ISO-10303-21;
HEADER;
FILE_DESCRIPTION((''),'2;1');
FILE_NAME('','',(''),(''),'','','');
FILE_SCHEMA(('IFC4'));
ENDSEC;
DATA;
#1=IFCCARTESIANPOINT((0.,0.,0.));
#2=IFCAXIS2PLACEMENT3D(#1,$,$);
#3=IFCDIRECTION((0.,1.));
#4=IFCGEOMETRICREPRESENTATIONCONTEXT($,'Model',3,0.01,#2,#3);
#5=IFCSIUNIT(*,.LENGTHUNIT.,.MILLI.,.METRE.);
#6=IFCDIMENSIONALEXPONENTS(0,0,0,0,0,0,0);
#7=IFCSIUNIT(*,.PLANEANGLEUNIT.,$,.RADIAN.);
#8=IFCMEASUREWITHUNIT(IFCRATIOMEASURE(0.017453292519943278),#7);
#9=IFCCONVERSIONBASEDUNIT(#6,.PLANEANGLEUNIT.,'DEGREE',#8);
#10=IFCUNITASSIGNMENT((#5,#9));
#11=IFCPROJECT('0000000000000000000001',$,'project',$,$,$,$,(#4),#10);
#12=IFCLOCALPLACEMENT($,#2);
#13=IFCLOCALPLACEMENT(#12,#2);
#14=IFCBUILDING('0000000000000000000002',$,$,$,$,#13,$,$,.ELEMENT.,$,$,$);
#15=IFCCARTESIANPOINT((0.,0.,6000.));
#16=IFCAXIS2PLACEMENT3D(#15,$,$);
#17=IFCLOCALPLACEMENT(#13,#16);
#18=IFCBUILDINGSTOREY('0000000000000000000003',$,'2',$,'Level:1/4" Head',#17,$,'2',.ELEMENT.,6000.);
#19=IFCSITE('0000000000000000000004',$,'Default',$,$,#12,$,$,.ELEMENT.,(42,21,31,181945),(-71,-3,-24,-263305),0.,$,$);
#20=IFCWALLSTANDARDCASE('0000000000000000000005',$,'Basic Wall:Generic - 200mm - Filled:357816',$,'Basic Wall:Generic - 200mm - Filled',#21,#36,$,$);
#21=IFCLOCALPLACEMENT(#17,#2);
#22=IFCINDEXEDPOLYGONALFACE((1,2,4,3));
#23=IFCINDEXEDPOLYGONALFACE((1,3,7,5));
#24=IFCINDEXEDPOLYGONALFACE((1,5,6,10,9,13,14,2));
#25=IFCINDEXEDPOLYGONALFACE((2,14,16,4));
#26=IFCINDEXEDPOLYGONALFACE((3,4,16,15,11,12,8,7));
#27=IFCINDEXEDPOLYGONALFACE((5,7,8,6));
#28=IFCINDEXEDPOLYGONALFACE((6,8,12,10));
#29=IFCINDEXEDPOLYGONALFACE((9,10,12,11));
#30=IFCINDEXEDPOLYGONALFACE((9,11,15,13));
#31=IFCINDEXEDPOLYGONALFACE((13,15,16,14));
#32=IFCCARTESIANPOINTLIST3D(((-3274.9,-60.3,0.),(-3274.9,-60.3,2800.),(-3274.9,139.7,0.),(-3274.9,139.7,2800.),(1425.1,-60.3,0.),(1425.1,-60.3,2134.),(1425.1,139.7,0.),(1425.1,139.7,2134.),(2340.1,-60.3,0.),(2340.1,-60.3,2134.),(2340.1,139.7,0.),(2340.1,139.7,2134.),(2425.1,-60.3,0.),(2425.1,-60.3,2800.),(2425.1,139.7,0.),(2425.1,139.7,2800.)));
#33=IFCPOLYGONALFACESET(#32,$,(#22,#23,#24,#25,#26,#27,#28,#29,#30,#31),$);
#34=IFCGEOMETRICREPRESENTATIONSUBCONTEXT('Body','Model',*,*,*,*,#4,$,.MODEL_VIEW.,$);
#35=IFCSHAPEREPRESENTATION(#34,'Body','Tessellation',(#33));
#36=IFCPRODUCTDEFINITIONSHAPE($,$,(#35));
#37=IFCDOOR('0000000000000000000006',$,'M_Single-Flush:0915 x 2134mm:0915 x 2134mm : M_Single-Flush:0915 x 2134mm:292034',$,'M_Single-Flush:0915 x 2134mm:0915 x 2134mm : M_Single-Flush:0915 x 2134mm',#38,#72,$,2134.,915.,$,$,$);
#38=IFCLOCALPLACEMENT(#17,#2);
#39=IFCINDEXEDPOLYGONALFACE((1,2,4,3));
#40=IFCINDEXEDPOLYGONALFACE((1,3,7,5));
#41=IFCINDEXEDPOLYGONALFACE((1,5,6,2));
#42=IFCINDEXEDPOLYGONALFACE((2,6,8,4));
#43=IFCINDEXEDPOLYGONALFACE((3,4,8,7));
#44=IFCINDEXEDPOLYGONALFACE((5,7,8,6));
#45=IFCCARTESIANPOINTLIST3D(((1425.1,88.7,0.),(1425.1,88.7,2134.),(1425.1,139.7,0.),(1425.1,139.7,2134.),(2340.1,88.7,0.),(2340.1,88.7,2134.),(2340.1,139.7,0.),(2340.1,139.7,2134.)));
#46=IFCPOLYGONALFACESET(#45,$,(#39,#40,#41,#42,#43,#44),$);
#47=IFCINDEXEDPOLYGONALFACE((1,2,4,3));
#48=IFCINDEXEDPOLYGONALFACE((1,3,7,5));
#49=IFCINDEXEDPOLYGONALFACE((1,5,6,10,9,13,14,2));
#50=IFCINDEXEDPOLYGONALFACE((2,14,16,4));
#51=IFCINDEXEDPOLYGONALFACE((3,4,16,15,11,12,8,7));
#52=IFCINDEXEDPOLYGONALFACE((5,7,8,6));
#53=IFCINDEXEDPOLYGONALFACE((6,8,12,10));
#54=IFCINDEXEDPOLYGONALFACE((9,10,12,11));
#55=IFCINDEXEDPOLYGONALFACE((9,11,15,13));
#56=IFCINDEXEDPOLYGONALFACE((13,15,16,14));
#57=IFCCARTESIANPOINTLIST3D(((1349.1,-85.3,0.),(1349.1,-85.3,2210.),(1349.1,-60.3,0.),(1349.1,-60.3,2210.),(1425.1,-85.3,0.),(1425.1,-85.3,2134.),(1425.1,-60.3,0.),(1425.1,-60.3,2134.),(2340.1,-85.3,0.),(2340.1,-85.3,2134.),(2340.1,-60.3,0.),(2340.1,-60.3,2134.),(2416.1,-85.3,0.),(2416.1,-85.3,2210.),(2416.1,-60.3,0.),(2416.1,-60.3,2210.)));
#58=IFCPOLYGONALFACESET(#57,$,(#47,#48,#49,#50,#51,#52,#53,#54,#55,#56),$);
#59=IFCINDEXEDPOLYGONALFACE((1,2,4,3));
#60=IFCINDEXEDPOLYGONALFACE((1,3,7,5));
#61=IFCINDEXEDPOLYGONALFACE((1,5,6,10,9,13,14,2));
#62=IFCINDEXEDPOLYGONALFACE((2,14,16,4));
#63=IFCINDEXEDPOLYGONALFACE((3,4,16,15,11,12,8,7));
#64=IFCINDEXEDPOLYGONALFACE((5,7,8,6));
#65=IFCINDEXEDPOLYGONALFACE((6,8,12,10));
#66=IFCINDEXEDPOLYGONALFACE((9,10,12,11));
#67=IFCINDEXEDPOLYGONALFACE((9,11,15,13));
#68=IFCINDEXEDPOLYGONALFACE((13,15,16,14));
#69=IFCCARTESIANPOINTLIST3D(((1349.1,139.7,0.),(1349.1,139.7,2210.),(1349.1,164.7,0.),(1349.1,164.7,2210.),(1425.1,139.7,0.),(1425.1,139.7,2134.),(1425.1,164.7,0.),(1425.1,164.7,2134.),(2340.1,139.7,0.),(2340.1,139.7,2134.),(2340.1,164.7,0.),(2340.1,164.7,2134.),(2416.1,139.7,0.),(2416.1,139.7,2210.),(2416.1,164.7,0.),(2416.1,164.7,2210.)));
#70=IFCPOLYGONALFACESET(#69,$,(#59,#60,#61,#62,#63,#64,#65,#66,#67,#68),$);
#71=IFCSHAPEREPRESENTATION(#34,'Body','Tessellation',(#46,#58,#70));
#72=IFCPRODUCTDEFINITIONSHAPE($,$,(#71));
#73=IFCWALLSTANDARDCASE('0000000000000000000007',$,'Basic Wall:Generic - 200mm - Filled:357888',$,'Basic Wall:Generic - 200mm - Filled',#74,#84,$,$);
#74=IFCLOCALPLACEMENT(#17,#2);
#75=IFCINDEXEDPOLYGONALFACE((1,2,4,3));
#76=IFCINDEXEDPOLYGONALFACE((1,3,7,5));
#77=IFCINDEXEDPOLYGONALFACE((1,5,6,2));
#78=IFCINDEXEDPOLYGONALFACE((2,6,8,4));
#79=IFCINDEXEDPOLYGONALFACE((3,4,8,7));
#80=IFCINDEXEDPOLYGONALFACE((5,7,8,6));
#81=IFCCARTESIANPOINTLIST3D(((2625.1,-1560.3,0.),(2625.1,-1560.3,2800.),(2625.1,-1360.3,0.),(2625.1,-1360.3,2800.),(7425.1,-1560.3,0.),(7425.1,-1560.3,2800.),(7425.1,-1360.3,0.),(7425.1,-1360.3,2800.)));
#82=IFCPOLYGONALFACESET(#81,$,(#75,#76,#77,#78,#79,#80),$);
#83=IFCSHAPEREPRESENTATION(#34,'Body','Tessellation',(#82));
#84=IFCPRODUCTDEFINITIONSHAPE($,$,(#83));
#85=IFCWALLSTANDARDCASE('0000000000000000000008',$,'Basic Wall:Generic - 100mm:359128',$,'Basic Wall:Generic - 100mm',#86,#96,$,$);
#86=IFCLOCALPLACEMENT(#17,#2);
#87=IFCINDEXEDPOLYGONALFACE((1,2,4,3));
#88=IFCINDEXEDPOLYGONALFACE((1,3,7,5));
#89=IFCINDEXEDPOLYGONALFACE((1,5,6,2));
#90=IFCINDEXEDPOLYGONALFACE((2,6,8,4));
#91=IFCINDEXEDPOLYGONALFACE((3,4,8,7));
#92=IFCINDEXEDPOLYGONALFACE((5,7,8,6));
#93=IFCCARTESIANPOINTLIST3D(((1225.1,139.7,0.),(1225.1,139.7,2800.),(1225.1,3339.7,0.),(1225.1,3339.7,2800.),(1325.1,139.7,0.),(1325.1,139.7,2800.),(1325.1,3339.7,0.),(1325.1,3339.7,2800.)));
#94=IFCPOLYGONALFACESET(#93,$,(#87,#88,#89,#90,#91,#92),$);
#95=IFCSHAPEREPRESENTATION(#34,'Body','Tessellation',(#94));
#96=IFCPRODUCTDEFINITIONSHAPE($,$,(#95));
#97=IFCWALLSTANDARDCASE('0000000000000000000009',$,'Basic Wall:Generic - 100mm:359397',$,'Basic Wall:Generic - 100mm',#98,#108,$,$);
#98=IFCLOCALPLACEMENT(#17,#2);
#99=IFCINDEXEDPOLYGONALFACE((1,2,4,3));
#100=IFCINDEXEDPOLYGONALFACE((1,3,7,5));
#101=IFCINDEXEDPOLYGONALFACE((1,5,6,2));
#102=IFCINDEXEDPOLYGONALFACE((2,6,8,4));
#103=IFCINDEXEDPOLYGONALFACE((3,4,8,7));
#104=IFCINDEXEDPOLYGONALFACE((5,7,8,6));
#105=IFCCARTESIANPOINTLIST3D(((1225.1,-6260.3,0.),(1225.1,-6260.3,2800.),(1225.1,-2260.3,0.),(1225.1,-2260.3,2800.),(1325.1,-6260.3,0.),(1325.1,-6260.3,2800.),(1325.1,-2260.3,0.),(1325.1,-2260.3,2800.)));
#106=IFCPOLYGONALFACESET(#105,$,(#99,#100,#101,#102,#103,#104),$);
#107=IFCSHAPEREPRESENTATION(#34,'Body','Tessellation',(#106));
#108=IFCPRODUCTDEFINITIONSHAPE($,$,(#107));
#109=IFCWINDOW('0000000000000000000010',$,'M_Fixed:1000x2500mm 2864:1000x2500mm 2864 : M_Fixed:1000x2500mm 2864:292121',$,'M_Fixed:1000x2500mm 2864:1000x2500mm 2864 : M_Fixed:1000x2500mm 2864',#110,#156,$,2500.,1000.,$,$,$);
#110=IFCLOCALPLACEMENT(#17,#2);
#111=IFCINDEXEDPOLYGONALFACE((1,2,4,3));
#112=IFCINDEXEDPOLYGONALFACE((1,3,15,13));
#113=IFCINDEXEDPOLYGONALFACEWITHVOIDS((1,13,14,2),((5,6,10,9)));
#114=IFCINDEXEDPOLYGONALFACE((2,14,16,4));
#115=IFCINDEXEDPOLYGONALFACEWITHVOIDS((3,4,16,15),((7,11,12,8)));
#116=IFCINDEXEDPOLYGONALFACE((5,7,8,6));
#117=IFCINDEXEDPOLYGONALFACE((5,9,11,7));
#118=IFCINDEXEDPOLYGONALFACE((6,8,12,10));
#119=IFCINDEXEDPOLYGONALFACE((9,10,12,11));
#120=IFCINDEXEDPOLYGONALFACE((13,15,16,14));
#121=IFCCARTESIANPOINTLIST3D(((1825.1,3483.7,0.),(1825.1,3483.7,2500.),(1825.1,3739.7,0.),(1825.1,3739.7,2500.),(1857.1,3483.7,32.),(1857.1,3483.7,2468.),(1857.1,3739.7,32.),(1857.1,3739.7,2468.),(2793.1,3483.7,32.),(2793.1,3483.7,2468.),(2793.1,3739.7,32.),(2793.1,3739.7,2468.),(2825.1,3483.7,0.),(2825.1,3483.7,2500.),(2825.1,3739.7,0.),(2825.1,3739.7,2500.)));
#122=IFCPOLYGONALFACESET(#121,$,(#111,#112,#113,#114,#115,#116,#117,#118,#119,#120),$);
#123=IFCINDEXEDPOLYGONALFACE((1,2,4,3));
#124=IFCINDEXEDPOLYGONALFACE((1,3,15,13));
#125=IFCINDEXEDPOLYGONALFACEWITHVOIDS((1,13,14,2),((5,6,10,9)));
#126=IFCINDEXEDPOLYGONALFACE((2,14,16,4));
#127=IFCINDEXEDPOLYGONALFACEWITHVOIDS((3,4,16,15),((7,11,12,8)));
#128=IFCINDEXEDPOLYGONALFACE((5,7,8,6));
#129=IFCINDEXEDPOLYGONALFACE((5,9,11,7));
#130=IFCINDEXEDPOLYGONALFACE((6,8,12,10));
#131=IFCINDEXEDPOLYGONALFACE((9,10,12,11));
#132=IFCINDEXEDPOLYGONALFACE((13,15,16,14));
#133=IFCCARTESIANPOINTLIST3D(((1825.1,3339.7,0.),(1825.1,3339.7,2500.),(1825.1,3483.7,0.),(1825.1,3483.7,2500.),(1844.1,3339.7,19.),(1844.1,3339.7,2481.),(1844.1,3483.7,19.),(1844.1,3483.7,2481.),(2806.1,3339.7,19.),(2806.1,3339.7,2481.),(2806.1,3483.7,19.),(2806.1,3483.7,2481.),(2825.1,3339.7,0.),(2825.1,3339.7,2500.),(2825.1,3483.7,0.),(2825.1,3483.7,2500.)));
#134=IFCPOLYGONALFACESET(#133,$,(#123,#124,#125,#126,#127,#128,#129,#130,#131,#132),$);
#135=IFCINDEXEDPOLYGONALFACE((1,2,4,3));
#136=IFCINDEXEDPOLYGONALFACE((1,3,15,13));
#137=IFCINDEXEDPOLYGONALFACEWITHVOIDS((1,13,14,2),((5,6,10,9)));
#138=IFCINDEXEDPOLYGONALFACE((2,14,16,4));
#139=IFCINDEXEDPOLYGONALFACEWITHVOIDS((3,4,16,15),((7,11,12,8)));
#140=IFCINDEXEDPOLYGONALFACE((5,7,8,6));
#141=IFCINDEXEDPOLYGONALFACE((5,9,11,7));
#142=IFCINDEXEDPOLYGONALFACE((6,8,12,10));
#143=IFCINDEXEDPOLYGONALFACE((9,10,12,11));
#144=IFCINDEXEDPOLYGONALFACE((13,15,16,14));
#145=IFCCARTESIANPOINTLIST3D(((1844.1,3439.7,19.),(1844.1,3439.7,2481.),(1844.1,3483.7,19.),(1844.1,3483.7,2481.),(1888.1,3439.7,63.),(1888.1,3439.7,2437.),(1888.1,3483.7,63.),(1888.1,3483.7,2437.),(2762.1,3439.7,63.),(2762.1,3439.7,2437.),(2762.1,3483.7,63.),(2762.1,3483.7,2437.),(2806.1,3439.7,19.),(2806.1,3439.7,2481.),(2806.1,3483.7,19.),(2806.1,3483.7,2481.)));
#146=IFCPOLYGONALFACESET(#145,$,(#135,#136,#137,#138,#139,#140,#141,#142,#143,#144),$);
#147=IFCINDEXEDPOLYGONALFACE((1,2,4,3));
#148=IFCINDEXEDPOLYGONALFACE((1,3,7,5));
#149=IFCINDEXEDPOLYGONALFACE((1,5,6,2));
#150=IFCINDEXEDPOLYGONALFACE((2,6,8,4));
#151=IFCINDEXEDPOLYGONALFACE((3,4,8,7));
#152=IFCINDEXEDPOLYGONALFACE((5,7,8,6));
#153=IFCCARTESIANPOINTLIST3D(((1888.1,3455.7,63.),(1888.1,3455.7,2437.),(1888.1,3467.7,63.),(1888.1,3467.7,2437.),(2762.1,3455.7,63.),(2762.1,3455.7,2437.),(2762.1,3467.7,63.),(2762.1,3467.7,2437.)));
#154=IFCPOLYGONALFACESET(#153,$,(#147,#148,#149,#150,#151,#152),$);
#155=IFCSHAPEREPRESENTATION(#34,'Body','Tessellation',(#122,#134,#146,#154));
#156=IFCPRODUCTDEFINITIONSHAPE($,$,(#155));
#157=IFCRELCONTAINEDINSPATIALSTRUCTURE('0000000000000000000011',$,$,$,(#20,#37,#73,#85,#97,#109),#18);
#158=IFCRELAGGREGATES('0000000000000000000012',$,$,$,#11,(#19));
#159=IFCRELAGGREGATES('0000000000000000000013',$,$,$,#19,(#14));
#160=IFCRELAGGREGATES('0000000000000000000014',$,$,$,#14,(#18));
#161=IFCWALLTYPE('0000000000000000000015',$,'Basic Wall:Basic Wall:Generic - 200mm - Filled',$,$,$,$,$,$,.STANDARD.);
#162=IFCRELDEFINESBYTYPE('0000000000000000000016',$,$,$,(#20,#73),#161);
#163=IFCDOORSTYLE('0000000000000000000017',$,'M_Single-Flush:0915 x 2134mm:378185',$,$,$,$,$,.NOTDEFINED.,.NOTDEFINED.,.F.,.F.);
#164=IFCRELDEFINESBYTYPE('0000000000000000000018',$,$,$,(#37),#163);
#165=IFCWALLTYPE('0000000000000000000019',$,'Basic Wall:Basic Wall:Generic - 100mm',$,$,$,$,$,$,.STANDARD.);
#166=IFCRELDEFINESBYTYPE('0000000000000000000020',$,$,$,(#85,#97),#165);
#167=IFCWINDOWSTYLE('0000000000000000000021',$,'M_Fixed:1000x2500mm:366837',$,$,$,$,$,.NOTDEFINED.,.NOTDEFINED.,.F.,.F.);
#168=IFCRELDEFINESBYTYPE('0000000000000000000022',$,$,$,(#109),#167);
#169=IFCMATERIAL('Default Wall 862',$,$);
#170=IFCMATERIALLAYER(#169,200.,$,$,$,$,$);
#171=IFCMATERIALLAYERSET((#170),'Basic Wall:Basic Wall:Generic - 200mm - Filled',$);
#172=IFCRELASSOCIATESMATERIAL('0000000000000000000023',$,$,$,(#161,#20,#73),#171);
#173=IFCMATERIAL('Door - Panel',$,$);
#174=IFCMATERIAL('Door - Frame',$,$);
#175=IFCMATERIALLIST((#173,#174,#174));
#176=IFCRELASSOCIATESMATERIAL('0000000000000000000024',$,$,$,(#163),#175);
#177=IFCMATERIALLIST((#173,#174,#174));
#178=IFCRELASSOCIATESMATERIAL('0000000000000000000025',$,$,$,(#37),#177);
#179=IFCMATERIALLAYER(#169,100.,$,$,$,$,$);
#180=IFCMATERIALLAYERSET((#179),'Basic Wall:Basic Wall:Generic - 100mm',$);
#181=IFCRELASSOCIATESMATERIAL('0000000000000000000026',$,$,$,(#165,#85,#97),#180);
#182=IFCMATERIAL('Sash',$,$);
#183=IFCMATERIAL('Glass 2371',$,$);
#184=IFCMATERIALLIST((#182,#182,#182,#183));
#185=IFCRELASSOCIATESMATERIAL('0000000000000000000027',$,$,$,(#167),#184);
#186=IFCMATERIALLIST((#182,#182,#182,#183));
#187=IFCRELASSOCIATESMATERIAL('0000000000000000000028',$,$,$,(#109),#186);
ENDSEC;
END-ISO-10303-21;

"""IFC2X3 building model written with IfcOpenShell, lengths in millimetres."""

from ifc_helpers import new_model, entity, si_unit, converted_unit, direction, frame, frame_2d, origin, origin_2d_with_axis, place, context, subcontext, project, spatial, polyline, rectangle, outline, extrude, source, transform, mapped, material, material_list, layer, layer_set, layer_usage, type_object, type_shapes, element, fill, save


model = new_model("IFC2X3")

# Units and contexts
model_context = context("Model", 3, precision=0.01, world=origin(), true_north=direction((0.0, 1.0)))
body_context = subcontext(model_context, "Body", "Model", "MODEL_VIEW")
ifc_project = project(units=[si_unit("LENGTHUNIT", "METRE", prefix="MILLI"), converted_unit("PLANEANGLEUNIT", "DEGREE", entity("IfcRatioMeasure", 0.017453292519943278), si_unit("PLANEANGLEUNIT", "RADIAN"), dimensions=[0, 0, 0, 0, 0, 0, 0])], contexts=[model_context])

# Site, building, storey
site_placement = place(None, origin())
site = spatial("IfcSite", under=ifc_project, at=site_placement, Name="Default", CompositionType="ELEMENT", RefLatitude=(42, 21, 31, 181945), RefLongitude=(-71, -3, -24, -263305), RefElevation=0.0)
building_placement = place(site_placement, origin())
building = spatial("IfcBuilding", under=site, at=building_placement, CompositionType="ELEMENT")
storey_placement = place(building_placement, frame((0.0, 0.0, 6000.0)))
storey = spatial("IfcBuildingStorey", under=building, at=storey_placement, Name="2", ObjectType="Level:1/4\" Head", LongName="2", CompositionType="ELEMENT", Elevation=6000.0)

# Shared definitions
ifc_material_1 = material(Name="Default Wall 862")
ifc_layer_1 = layer(ifc_material_1, 200.0)
ifc_layer_set_1 = layer_set([ifc_layer_1], Name="Basic Wall:Basic Wall:Generic - 200mm - Filled")
wall_type_1 = type_object("IfcWallType", Name="Basic Wall:Basic Wall:Generic - 200mm - Filled", PredefinedType="STANDARD", material=ifc_layer_set_1)
ifc_material_2 = material(Name="Door - Panel")
ifc_material_3 = material(Name="Door - Frame")

# Wall, opening, door
ifc_layer_usage_1 = layer_usage(ifc_layer_set_1, "AXIS2", "NEGATIVE", 100.0)
wall_1_placement = place(storey_placement, frame((2425.1, 39.7, 0.0), z_axis=(0.0, 0.0, 1.0), x_axis=(-1.0, 0.0, 0.0)))
wall_1 = element("IfcWallStandardCase", 1, at=wall_1_placement, inside=storey, type_object=wall_type_1, material=ifc_layer_usage_1, Name="Basic Wall:Generic - 200mm - Filled:357816", ObjectType="Basic Wall:Generic - 200mm - Filled", context=body_context, shape_type="SweptSolid", body=[
    extrude(rectangle(XDim=5700.0, YDim=200.0, at=frame_2d((2850.0, 0.0), x_axis=(1.0, 0.0))), origin(), (0.0, 0.0, 1.0), 2800.0),
])
opening_1_placement = place(wall_1_placement, frame((2425.1, 39.7, 0.0), z_axis=(0.0, 0.0, 1.0), x_axis=(-1.0, 0.0, 0.0)))
opening_1 = element("IfcOpeningElement", 2, at=opening_1_placement, cuts=wall_1, ObjectType="Opening", context=body_context, shape_type="SweptSolid", body=[
    extrude(rectangle(XDim=2134.0, YDim=915.0, at=frame_2d((0.0, 0.0), x_axis=(0.0, 1.0))), frame((1882.6, 141.7, 1067.0), z_axis=(0.0, -1.0, 0.0), x_axis=(1.0, 0.0, 0.0)), (0.0, 0.0, 1.0), 204.0),
])
ifc_material_list_1 = material_list([ifc_material_2, ifc_material_3, ifc_material_3])
ifc_material_list_2 = material_list([ifc_material_2, ifc_material_3, ifc_material_3])
door_style_1 = type_object("IfcDoorStyle", Name="M_Single-Flush:0915 x 2134mm:378185", ConstructionType="NOTDEFINED", OperationType="NOTDEFINED", ParameterTakesPrecedence=False, Sizeable=False, material=ifc_material_list_2)
shared_shape_1 = source(origin(), body_context, "Body", "SweptSolid", [
    extrude(rectangle(XDim=51.0, YDim=915.0, at=origin_2d_with_axis()), frame((457.5, 176.5, 0.0), z_axis=(0.0, 0.0, 1.0), x_axis=(0.0, 1.0, 0.0)), (0.0, 0.0, 1.0), 2134.0),
    extrude(outline(polyline([(-1086.0, -533.5), (1124.0, -533.5), (1124.0, 533.5), (-1086.0, 533.5), (-1086.0, 457.5), (1048.0, 457.5), (1048.0, -457.5), (-1086.0, -457.5), (-1086.0, -533.5)])), frame((457.5, -23.0, 1086.0), z_axis=(0.0, 1.0, 0.0), x_axis=(0.0, 0.0, 1.0)), (0.0, 0.0, 1.0), 25.0),
    extrude(outline(polyline([(-533.5, -1124.0), (533.5, -1124.0), (533.5, 1086.0), (457.5, 1086.0), (457.5, -1048.0), (-457.5, -1048.0), (-457.5, 1086.0), (-533.5, 1086.0), (-533.5, -1124.0)])), frame((457.5, 202.0, 1086.0), z_axis=(0.0, 1.0, 0.0), x_axis=(1.0, 0.0, 0.0)), (0.0, 0.0, 1.0), 25.0),
])
type_shapes(door_style_1, [shared_shape_1])
door_1_placement = place(opening_1_placement, frame((1425.1, -62.3, 0.0)))
door_1 = element("IfcDoor", 3, at=door_1_placement, inside=storey, type_object=door_style_1, material=ifc_material_list_1, Name="M_Single-Flush:0915 x 2134mm:0915 x 2134mm : M_Single-Flush:0915 x 2134mm:292034", ObjectType="M_Single-Flush:0915 x 2134mm:0915 x 2134mm : M_Single-Flush:0915 x 2134mm", OverallHeight=2134.0, OverallWidth=915.0, context=body_context, shape_type="MappedRepresentation", body=[
    mapped(shared_shape_1, transform((0.0, 0.0, 0.0), scale=1.0)),
])
fill(opening_1, door_1)

# Walls
ifc_layer_usage_2 = layer_usage(ifc_layer_set_1, "AXIS2", "NEGATIVE", 100.0)
wall_2_placement = place(storey_placement, frame((2625.1, -1460.3, 0.0)))
element("IfcWallStandardCase", 4, at=wall_2_placement, inside=storey, type_object=wall_type_1, material=ifc_layer_usage_2, Name="Basic Wall:Generic - 200mm - Filled:357888", ObjectType="Basic Wall:Generic - 200mm - Filled", context=body_context, shape_type="SweptSolid", body=[
    extrude(rectangle(XDim=4800.0, YDim=200.0, at=frame_2d((2400.0, 0.0), x_axis=(-1.0, 0.0))), origin(), (0.0, 0.0, 1.0), 2800.0),
])
ifc_layer_2 = layer(ifc_material_1, 100.0)
ifc_layer_set_2 = layer_set([ifc_layer_2], Name="Basic Wall:Basic Wall:Generic - 100mm")
ifc_layer_usage_3 = layer_usage(ifc_layer_set_2, "AXIS2", "NEGATIVE", 50.0)
wall_type_2 = type_object("IfcWallType", Name="Basic Wall:Basic Wall:Generic - 100mm", PredefinedType="STANDARD", material=ifc_layer_set_2)
wall_3_placement = place(storey_placement, frame((1275.1, 139.7, 0.0), z_axis=(0.0, 0.0, 1.0), x_axis=(0.0, 1.0, 0.0)))
element("IfcWallStandardCase", 5, at=wall_3_placement, inside=storey, type_object=wall_type_2, material=ifc_layer_usage_3, Name="Basic Wall:Generic - 100mm:359128", ObjectType="Basic Wall:Generic - 100mm", context=body_context, shape_type="SweptSolid", body=[
    extrude(rectangle(XDim=3200.0, YDim=100.0, at=frame_2d((1600.0, 0.0), x_axis=(-1.0, 0.0))), origin(), (0.0, 0.0, 1.0), 2800.0),
])
ifc_layer_usage_4 = layer_usage(ifc_layer_set_2, "AXIS2", "NEGATIVE", 50.0)
wall_4_placement = place(storey_placement, frame((1275.1, -2260.3, 0.0), z_axis=(0.0, 0.0, 1.0), x_axis=(0.0, -1.0, 0.0)))
element("IfcWallStandardCase", 6, at=wall_4_placement, inside=storey, type_object=wall_type_2, material=ifc_layer_usage_4, Name="Basic Wall:Generic - 100mm:359397", ObjectType="Basic Wall:Generic - 100mm", context=body_context, shape_type="SweptSolid", body=[
    extrude(rectangle(XDim=4000.0, YDim=100.0, at=frame_2d((2000.0, 0.0), x_axis=(-1.0, 0.0))), origin(), (0.0, 0.0, 1.0), 2800.0),
])

# Window
ifc_material_4 = material(Name="Sash")
ifc_material_5 = material(Name="Glass 2371")
ifc_material_list_3 = material_list([ifc_material_4, ifc_material_4, ifc_material_4, ifc_material_5])
ifc_material_list_4 = material_list([ifc_material_4, ifc_material_4, ifc_material_4, ifc_material_5])
window_style_1 = type_object("IfcWindowStyle", Name="M_Fixed:1000x2500mm:366837", ConstructionType="NOTDEFINED", OperationType="NOTDEFINED", ParameterTakesPrecedence=False, Sizeable=False, material=ifc_material_list_4)
shared_shape_2 = source(origin(), body_context, "Body", "SweptSolid", [
    extrude(outline(polyline([(-500.0, -1250.0), (500.0, -1250.0), (500.0, 1250.0), (-500.0, 1250.0), (-500.0, -1250.0)]), holes=[polyline([(468.0, 1218.0), (468.0, -1218.0), (-468.0, -1218.0), (-468.0, 1218.0), (468.0, 1218.0)])]), frame((2325.1, 3483.7, 7250.0), z_axis=(0.0, 1.0, 0.0), x_axis=(1.0, 0.0, 0.0)), (0.0, 0.0, 1.0), 256.0),
    extrude(outline(polyline([(-500.0, -1250.0), (500.0, -1250.0), (500.0, 1250.0), (-500.0, 1250.0), (-500.0, -1250.0)]), holes=[polyline([(481.0, 1231.0), (481.0, -1231.0), (-481.0, -1231.0), (-481.0, 1231.0), (481.0, 1231.0)])]), frame((2325.1, 3339.7, 7250.0), z_axis=(0.0, 1.0, 0.0), x_axis=(1.0, 0.0, 0.0)), (0.0, 0.0, 1.0), 144.0),
    extrude(outline(polyline([(-481.0, -1231.0), (481.0, -1231.0), (481.0, 1231.0), (-481.0, 1231.0), (-481.0, -1231.0)]), holes=[polyline([(437.0, 1187.0), (437.0, -1187.0), (-437.0, -1187.0), (-437.0, 1187.0), (437.0, 1187.0)])]), frame((2325.1, 3439.7, 7250.0), z_axis=(0.0, 1.0, 0.0), x_axis=(1.0, 0.0, 0.0)), (0.0, 0.0, 1.0), 44.0),
    extrude(rectangle(XDim=874.0, YDim=12.0, at=frame_2d((0.0, 0.0), x_axis=(1.0, 0.0))), frame((2325.1, 3461.7, 6063.0), z_axis=(0.0, 0.0, 1.0), x_axis=(-1.0, 0.0, 0.0)), (0.0, 0.0, 1.0), 2374.0),
])
type_shapes(window_style_1, [shared_shape_2])
window_1_placement = place(storey_placement, frame((0.0, 0.0, -6000.0)))
element("IfcWindow", 7, at=window_1_placement, inside=storey, type_object=window_style_1, material=ifc_material_list_3, Name="M_Fixed:1000x2500mm 2864:1000x2500mm 2864 : M_Fixed:1000x2500mm 2864:292121", ObjectType="M_Fixed:1000x2500mm 2864:1000x2500mm 2864 : M_Fixed:1000x2500mm 2864", OverallHeight=2500.0, OverallWidth=1000.0, context=body_context, shape_type="MappedRepresentation", body=[
    mapped(shared_shape_2, transform((0.0, 0.0, 0.0), scale=1.0)),
])

save(model, "model.ifc")
